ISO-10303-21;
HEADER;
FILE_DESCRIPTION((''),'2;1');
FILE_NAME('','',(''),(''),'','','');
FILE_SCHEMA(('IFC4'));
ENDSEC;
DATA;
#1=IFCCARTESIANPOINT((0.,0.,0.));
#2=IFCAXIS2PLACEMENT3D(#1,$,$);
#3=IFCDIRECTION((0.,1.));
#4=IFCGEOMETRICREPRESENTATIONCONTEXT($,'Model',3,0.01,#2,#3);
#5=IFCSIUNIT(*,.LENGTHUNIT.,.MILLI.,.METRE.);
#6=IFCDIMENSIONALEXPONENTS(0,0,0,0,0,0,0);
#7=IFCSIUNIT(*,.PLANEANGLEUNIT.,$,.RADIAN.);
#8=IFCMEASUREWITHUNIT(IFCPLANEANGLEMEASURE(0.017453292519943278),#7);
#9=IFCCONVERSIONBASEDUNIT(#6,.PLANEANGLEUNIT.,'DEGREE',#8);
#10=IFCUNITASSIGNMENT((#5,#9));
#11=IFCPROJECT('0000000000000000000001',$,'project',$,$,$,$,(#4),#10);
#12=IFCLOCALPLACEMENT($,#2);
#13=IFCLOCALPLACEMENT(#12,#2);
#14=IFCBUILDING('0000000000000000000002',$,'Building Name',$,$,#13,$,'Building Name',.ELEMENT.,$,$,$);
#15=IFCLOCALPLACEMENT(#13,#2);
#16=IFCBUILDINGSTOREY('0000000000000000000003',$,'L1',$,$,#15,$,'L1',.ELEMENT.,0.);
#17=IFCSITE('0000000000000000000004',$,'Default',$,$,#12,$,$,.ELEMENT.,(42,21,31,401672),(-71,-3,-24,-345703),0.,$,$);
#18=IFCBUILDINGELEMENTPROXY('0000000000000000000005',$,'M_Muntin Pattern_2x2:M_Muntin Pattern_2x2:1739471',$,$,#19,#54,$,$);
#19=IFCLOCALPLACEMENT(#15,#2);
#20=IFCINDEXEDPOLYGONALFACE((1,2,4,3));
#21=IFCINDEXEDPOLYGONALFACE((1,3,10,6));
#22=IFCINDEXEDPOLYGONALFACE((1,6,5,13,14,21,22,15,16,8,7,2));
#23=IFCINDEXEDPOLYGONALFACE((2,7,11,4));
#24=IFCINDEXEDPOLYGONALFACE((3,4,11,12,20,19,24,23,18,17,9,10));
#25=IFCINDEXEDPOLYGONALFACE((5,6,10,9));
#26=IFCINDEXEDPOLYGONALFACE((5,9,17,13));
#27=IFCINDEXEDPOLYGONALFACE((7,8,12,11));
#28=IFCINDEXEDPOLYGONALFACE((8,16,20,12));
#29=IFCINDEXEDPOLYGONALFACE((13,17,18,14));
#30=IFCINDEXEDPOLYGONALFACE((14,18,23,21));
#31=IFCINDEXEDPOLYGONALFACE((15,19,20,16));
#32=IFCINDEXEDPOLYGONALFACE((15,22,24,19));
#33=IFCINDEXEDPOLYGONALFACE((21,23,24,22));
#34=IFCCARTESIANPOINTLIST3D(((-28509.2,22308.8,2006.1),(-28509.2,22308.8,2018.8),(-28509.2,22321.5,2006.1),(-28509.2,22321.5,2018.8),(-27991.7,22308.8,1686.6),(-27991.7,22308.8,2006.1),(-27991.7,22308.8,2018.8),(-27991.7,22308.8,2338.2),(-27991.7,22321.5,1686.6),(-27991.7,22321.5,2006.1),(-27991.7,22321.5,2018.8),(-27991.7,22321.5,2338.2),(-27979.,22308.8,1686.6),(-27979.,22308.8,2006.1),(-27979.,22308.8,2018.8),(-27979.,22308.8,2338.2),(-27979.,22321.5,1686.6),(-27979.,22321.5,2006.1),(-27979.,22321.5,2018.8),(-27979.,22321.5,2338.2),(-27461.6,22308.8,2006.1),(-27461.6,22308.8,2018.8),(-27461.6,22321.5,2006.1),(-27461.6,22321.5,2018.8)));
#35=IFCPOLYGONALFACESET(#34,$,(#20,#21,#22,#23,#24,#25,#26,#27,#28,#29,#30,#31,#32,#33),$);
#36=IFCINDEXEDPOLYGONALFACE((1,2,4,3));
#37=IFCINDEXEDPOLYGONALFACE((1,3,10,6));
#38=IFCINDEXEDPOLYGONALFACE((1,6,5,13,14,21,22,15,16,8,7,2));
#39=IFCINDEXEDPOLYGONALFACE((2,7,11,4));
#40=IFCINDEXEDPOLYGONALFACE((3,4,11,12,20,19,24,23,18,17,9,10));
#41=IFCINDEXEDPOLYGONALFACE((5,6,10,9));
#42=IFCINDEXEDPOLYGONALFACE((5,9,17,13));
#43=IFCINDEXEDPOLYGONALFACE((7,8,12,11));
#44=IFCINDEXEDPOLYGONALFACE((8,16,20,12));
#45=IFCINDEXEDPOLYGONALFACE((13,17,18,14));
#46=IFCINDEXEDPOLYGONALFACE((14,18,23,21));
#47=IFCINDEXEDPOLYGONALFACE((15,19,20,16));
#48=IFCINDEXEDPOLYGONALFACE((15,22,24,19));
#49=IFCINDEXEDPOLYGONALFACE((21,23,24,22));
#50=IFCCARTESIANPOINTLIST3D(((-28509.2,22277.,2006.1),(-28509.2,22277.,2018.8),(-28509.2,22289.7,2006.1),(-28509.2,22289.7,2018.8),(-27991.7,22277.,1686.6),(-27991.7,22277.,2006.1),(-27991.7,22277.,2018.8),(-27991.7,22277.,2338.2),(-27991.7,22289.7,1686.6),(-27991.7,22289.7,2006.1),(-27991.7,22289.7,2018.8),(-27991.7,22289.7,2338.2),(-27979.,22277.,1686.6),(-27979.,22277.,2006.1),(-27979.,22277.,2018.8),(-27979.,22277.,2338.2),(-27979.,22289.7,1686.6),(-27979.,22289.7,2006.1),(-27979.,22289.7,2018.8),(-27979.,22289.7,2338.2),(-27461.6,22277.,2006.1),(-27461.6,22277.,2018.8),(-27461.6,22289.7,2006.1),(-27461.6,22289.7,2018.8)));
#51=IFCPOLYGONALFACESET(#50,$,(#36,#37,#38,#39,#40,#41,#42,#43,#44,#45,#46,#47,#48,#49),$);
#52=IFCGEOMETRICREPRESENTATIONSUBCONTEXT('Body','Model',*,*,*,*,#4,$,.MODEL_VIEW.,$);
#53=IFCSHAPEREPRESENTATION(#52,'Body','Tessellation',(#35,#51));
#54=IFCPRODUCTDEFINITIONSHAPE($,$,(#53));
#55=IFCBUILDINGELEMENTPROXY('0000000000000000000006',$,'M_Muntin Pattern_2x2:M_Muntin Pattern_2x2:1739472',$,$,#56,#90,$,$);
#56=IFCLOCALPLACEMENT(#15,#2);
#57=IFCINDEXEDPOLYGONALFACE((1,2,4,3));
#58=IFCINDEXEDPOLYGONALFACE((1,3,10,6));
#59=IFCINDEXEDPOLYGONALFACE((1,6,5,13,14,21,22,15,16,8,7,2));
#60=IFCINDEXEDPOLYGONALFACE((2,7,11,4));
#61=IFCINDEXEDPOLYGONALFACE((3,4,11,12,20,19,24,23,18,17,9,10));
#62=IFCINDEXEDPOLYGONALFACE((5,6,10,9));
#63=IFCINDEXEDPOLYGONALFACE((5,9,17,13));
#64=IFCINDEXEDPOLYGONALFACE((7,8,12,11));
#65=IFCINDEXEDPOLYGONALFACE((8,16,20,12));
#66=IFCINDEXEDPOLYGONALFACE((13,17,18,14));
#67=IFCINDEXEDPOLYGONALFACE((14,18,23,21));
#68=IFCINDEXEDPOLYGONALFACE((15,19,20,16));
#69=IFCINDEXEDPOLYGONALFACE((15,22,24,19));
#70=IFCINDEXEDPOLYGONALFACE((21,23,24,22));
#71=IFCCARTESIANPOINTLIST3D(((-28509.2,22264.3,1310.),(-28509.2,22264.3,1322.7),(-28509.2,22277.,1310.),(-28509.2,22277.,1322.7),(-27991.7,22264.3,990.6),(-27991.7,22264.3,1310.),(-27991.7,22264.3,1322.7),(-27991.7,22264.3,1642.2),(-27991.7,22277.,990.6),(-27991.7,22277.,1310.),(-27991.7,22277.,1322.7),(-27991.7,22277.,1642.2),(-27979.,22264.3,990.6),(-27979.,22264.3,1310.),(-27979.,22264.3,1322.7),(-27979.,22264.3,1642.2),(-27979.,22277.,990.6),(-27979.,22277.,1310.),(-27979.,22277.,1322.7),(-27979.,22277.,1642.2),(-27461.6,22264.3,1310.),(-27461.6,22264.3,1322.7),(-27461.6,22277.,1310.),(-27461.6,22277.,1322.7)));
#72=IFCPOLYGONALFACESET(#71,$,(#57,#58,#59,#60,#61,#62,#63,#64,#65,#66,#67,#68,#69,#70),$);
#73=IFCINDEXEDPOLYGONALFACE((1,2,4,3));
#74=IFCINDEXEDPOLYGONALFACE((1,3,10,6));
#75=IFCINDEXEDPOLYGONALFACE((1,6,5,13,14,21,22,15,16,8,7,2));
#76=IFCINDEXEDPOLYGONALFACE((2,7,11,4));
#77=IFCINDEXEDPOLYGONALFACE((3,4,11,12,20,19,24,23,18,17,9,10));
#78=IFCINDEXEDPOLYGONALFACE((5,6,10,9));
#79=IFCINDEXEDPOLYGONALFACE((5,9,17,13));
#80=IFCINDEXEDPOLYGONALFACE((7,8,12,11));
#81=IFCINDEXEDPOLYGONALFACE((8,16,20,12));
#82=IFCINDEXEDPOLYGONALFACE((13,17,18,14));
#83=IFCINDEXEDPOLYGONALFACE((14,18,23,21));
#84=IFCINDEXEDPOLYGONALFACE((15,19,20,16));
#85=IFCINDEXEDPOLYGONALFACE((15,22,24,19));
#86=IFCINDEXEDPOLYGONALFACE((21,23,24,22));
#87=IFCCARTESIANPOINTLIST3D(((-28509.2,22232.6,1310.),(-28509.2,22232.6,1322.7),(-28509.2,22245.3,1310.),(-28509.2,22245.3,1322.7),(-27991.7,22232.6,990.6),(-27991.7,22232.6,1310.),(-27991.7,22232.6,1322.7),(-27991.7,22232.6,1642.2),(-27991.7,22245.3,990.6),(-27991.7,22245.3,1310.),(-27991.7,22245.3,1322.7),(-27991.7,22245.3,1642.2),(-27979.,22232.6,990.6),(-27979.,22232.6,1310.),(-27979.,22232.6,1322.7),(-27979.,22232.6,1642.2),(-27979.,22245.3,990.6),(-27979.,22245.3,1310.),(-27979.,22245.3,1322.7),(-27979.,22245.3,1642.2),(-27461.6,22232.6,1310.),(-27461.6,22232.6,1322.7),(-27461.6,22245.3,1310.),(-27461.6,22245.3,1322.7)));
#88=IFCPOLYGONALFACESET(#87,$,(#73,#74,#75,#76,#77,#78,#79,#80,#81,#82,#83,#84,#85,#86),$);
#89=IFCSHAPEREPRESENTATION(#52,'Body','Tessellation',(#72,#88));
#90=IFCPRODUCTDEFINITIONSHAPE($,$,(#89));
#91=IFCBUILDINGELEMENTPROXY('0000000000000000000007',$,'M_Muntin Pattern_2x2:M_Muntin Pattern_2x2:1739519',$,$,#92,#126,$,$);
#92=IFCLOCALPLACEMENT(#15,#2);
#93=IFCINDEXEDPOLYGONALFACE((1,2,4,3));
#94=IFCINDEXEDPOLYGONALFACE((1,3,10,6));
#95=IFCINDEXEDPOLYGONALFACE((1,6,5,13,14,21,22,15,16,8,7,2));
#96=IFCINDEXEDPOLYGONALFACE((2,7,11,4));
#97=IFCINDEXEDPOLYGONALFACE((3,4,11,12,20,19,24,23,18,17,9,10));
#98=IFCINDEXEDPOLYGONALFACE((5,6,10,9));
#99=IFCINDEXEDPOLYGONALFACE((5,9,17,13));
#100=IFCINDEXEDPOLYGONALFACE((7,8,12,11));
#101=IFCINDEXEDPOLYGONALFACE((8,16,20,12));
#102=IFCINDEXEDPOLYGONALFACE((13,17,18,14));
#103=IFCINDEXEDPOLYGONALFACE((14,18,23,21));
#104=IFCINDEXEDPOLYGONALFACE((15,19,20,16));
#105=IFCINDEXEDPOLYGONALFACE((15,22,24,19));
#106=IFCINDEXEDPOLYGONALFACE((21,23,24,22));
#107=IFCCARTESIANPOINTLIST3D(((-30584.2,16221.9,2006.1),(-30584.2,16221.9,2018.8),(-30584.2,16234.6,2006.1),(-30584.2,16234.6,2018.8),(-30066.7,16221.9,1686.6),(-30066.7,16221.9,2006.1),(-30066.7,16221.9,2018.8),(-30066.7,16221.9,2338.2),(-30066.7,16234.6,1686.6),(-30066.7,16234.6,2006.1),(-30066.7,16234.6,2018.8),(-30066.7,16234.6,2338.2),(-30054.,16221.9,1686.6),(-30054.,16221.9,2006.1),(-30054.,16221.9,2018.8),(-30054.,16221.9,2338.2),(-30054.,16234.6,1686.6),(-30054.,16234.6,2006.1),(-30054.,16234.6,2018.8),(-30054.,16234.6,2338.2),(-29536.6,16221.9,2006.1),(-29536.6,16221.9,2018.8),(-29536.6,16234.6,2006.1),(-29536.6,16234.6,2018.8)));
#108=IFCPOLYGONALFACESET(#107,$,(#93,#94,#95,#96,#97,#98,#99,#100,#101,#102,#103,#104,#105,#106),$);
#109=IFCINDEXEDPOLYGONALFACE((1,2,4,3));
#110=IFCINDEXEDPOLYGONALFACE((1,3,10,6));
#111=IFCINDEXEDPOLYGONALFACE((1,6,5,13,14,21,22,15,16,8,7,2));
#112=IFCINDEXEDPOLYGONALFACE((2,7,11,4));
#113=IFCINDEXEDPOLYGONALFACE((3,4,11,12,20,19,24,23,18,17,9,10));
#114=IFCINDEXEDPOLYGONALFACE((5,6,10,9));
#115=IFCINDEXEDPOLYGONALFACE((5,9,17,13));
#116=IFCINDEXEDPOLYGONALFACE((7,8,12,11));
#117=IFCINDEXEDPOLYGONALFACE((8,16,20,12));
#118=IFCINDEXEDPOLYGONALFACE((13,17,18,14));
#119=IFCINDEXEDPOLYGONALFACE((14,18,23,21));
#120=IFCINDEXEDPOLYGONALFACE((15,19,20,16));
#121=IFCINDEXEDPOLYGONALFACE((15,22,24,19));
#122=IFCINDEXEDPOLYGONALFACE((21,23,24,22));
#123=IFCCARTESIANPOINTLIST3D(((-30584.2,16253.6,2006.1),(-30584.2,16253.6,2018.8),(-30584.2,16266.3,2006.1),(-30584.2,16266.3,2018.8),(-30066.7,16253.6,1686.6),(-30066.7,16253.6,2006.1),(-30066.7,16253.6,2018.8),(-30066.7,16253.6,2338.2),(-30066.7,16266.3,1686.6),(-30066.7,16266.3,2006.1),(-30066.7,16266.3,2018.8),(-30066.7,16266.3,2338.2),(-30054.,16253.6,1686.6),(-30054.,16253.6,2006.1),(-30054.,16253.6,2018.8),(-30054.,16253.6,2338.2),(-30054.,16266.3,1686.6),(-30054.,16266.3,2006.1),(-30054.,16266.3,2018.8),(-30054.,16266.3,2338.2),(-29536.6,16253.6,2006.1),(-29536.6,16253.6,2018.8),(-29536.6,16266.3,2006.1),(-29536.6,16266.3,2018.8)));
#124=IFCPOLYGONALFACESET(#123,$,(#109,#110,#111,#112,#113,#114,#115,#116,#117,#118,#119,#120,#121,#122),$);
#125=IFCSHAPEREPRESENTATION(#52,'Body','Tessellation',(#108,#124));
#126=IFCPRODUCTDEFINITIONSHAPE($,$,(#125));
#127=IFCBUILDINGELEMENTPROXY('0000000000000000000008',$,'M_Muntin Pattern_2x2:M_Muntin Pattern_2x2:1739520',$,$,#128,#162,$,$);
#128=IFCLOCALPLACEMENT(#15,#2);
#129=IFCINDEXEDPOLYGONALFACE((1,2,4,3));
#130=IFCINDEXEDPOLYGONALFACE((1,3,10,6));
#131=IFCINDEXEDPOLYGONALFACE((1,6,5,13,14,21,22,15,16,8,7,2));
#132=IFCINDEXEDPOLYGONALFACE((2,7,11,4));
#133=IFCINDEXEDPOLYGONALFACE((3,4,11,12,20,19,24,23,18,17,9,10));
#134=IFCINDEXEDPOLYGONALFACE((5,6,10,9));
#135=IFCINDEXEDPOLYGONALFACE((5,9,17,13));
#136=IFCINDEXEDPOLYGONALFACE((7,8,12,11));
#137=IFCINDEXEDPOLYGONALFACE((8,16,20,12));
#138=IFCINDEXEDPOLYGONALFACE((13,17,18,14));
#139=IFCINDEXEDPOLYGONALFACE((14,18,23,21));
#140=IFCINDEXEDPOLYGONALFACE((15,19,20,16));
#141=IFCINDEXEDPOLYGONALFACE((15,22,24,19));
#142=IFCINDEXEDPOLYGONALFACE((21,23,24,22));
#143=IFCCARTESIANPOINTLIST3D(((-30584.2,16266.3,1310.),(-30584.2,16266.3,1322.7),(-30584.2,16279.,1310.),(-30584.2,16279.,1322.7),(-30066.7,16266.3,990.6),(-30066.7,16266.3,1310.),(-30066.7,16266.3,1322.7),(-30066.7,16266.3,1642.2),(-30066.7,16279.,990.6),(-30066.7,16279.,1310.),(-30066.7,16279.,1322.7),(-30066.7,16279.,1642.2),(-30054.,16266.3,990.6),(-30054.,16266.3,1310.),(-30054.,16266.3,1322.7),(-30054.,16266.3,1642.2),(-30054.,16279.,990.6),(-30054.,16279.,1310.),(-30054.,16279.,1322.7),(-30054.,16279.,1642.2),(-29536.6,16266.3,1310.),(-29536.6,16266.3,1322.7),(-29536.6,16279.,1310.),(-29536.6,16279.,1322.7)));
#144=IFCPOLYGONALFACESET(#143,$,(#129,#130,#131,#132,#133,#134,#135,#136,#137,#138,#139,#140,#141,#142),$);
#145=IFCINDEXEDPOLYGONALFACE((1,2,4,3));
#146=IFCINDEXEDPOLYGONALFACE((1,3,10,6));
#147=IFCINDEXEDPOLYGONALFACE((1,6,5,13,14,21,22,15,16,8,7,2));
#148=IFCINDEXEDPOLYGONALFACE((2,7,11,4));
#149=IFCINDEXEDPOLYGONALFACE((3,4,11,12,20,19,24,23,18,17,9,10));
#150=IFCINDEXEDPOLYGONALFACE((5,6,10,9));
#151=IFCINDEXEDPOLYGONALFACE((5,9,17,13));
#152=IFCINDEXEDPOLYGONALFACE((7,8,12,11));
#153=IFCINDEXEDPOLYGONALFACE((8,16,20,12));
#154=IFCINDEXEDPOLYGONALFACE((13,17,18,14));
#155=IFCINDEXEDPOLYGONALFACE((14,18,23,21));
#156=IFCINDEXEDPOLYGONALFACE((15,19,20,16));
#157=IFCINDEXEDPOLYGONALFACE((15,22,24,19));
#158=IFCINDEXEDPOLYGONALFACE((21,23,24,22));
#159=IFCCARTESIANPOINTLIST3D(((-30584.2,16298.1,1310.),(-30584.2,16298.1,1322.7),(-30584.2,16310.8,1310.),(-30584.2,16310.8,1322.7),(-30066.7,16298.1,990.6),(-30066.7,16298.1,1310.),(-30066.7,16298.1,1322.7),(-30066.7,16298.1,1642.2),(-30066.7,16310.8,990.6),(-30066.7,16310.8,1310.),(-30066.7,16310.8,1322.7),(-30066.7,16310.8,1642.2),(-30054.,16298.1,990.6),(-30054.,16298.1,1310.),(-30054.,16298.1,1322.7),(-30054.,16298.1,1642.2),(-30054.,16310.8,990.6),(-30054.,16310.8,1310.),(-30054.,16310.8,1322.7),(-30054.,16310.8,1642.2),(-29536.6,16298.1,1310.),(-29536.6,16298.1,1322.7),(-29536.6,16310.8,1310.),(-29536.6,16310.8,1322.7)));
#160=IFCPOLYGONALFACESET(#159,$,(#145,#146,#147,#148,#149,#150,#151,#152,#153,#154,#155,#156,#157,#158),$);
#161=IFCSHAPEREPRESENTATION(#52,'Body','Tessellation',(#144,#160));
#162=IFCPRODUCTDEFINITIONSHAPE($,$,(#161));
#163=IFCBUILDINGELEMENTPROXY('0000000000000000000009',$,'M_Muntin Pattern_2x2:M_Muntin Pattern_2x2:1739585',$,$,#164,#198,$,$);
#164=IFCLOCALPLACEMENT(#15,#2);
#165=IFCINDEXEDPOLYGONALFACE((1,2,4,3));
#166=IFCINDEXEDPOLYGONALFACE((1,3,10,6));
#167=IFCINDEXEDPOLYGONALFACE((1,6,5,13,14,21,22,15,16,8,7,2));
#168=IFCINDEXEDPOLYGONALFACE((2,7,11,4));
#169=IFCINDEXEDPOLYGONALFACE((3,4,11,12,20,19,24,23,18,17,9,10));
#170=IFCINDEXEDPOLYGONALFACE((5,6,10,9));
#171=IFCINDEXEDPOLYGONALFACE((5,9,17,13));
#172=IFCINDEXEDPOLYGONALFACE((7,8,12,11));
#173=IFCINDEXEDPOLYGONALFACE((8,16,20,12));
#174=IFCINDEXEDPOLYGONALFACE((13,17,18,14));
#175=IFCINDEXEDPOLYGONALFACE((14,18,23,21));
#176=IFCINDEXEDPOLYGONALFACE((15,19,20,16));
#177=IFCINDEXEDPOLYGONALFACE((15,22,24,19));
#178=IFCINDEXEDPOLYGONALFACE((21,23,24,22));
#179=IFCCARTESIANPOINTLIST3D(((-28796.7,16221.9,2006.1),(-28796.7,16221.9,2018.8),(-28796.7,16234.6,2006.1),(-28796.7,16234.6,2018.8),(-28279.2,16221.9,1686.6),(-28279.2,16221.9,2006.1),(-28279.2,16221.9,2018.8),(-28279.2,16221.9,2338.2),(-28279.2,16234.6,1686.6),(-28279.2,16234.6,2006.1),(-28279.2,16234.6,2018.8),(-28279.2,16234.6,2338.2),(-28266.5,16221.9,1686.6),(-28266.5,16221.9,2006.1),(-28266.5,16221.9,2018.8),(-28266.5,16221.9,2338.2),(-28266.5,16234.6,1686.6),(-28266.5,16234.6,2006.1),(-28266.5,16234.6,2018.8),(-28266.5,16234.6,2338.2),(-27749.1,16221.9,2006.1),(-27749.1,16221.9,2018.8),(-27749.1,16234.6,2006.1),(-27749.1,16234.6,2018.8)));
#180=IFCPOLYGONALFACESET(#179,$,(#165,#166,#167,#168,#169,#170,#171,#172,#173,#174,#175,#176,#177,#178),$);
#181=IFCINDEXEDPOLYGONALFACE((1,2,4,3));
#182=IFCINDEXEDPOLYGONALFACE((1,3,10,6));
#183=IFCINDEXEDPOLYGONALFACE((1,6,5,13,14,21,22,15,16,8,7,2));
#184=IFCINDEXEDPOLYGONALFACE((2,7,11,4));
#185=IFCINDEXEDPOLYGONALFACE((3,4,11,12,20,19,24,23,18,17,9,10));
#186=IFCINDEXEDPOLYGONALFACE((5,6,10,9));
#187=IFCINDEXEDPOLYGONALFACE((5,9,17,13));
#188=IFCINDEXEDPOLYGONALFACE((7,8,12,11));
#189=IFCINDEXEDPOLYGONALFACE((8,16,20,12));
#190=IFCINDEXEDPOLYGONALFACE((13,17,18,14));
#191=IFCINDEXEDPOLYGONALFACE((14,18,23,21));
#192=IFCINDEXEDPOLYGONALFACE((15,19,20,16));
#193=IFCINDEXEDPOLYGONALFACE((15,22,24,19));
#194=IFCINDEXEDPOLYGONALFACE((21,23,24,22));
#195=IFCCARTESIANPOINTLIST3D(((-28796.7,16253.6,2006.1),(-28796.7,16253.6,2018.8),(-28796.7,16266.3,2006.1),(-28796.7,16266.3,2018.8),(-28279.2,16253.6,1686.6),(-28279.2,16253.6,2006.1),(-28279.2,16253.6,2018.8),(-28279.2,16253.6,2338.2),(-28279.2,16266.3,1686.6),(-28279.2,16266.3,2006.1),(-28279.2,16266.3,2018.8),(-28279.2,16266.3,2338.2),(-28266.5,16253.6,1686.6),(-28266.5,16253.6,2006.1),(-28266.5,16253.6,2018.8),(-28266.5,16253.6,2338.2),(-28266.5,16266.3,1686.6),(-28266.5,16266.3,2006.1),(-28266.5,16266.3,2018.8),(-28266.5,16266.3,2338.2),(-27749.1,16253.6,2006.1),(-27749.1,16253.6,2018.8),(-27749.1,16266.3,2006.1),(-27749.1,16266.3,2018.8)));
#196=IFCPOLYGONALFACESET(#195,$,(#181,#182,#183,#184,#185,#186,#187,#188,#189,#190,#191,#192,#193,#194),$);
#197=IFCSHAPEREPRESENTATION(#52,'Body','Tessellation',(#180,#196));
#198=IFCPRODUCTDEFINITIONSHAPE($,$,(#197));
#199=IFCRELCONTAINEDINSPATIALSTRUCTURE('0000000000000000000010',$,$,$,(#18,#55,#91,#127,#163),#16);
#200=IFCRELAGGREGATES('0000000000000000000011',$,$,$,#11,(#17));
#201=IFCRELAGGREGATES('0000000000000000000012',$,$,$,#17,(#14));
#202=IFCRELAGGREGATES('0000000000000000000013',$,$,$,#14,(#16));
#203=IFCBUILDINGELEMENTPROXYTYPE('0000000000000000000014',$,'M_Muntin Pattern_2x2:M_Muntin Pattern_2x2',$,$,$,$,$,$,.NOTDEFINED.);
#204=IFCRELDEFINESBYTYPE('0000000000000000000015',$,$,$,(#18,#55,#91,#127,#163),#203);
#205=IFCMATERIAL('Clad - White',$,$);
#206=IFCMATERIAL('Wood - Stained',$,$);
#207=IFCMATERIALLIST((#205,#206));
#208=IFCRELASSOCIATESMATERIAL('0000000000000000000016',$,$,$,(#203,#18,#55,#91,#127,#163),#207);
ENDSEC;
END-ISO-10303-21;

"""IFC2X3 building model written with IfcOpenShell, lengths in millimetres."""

from ifc_helpers import new_model, entity, si_unit, converted_unit, direction, frame, origin, place, context, subcontext, project, spatial, polyline, outline, extrude, source, transform, mapped, material, material_list, type_object, type_shapes, element, save


model = new_model("IFC2X3")

# Units and contexts
model_context = context("Model", 3, precision=0.01, world=origin(), true_north=direction((0.0, 1.0)))
body_context = subcontext(model_context, "Body", "Model", "MODEL_VIEW")
ifc_project = project(units=[si_unit("LENGTHUNIT", "METRE", prefix="MILLI"), converted_unit("PLANEANGLEUNIT", "DEGREE", entity("IfcPlaneAngleMeasure", 0.017453292519943278), si_unit("PLANEANGLEUNIT", "RADIAN"), dimensions=[0, 0, 0, 0, 0, 0, 0])], contexts=[model_context])

# Site, building, storey
site_placement = place(None, origin())
site = spatial("IfcSite", under=ifc_project, at=site_placement, Name="Default", CompositionType="ELEMENT", RefLatitude=(42, 21, 31, 401672), RefLongitude=(-71, -3, -24, -345703), RefElevation=0.0)
building_placement = place(site_placement, origin())
building = spatial("IfcBuilding", under=site, at=building_placement, Name="Building Name", LongName="Building Name", CompositionType="ELEMENT")
storey_placement = place(building_placement, origin())
storey = spatial("IfcBuildingStorey", under=building, at=storey_placement, Name="L1", LongName="L1", CompositionType="ELEMENT", Elevation=0.0)

# Shared definitions
ifc_material_1 = material(Name="Wood - Stained")

# Building element proxies
ifc_material_2 = material(Name="Clad - White")
ifc_material_list_1 = material_list([ifc_material_2, ifc_material_1])
building_element_proxy_type_1 = type_object("IfcBuildingElementProxyType", Name="M_Muntin Pattern_2x2:M_Muntin Pattern_2x2", PredefinedType="NOTDEFINED", material=ifc_material_list_1)
shared_shape_1 = source(origin(), body_context, "Body", "SweptSolid", [
    extrude(outline(polyline([(6.4, -6.4), (325.8, -6.4), (325.8, 6.3), (6.4, 6.3), (6.4, 523.8), (-6.3, 523.8), (-6.3, 6.3), (-325.8, 6.3), (-325.8, -6.4), (-6.3, -6.4), (-6.3, -523.8), (6.4, -523.8), (6.4, -6.4)])), frame((0.0, 9.5, 325.8), z_axis=(0.0, 1.0, 0.0), x_axis=(0.0, 0.0, 1.0)), (0.0, 0.0, 1.0), 12.7),
    extrude(outline(polyline([(6.4, -6.4), (325.8, -6.4), (325.8, 6.3), (6.4, 6.3), (6.4, 523.8), (-6.3, 523.8), (-6.3, 6.3), (-325.8, 6.3), (-325.8, -6.4), (-6.3, -6.4), (-6.3, -523.8), (6.4, -523.8), (6.4, -6.4)])), frame((0.0, -22.2, 325.8), z_axis=(0.0, 1.0, 0.0), x_axis=(0.0, 0.0, 1.0)), (0.0, 0.0, 1.0), 12.7),
])
type_shapes(building_element_proxy_type_1, [shared_shape_1])
for number, where, name in (
    (1, (-27985.4, 22299.3, 1686.6), "M_Muntin Pattern_2x2:M_Muntin Pattern_2x2:1739471"),
    (2, (-27985.4, 22254.8, 990.6), "M_Muntin Pattern_2x2:M_Muntin Pattern_2x2:1739472"),
):
    element("IfcBuildingElementProxy", number, at=place(storey_placement, frame(where)), inside=storey, type_object=building_element_proxy_type_1, material=ifc_material_list_1, Name=name, context=body_context, shape_type="MappedRepresentation", body=[
        mapped(shared_shape_1, transform((0.0, 0.0, 0.0), scale=1.0)),
    ])
for number, where, z_axis, x_axis, name in (
    (3, (-30060.4, 16244.1, 1686.6), (0.0, 0.0, 1.0), (-1.0, 0.0, 0.0), "M_Muntin Pattern_2x2:M_Muntin Pattern_2x2:1739519"),
    (4, (-30060.4, 16288.6, 990.6), (0.0, 0.0, 1.0), (-1.0, 0.0, 0.0), "M_Muntin Pattern_2x2:M_Muntin Pattern_2x2:1739520"),
    (5, (-28272.9, 16244.1, 1686.6), (0.0, 0.0, 1.0), (-1.0, 0.0, 0.0), "M_Muntin Pattern_2x2:M_Muntin Pattern_2x2:1739585"),
):
    element("IfcBuildingElementProxy", number, at=place(storey_placement, frame(where, z_axis=z_axis, x_axis=x_axis)), inside=storey, type_object=building_element_proxy_type_1, material=ifc_material_list_1, Name=name, context=body_context, shape_type="MappedRepresentation", body=[
        mapped(shared_shape_1, transform((0.0, 0.0, 0.0), scale=1.0)),
    ])

save(model, "model.ifc")
